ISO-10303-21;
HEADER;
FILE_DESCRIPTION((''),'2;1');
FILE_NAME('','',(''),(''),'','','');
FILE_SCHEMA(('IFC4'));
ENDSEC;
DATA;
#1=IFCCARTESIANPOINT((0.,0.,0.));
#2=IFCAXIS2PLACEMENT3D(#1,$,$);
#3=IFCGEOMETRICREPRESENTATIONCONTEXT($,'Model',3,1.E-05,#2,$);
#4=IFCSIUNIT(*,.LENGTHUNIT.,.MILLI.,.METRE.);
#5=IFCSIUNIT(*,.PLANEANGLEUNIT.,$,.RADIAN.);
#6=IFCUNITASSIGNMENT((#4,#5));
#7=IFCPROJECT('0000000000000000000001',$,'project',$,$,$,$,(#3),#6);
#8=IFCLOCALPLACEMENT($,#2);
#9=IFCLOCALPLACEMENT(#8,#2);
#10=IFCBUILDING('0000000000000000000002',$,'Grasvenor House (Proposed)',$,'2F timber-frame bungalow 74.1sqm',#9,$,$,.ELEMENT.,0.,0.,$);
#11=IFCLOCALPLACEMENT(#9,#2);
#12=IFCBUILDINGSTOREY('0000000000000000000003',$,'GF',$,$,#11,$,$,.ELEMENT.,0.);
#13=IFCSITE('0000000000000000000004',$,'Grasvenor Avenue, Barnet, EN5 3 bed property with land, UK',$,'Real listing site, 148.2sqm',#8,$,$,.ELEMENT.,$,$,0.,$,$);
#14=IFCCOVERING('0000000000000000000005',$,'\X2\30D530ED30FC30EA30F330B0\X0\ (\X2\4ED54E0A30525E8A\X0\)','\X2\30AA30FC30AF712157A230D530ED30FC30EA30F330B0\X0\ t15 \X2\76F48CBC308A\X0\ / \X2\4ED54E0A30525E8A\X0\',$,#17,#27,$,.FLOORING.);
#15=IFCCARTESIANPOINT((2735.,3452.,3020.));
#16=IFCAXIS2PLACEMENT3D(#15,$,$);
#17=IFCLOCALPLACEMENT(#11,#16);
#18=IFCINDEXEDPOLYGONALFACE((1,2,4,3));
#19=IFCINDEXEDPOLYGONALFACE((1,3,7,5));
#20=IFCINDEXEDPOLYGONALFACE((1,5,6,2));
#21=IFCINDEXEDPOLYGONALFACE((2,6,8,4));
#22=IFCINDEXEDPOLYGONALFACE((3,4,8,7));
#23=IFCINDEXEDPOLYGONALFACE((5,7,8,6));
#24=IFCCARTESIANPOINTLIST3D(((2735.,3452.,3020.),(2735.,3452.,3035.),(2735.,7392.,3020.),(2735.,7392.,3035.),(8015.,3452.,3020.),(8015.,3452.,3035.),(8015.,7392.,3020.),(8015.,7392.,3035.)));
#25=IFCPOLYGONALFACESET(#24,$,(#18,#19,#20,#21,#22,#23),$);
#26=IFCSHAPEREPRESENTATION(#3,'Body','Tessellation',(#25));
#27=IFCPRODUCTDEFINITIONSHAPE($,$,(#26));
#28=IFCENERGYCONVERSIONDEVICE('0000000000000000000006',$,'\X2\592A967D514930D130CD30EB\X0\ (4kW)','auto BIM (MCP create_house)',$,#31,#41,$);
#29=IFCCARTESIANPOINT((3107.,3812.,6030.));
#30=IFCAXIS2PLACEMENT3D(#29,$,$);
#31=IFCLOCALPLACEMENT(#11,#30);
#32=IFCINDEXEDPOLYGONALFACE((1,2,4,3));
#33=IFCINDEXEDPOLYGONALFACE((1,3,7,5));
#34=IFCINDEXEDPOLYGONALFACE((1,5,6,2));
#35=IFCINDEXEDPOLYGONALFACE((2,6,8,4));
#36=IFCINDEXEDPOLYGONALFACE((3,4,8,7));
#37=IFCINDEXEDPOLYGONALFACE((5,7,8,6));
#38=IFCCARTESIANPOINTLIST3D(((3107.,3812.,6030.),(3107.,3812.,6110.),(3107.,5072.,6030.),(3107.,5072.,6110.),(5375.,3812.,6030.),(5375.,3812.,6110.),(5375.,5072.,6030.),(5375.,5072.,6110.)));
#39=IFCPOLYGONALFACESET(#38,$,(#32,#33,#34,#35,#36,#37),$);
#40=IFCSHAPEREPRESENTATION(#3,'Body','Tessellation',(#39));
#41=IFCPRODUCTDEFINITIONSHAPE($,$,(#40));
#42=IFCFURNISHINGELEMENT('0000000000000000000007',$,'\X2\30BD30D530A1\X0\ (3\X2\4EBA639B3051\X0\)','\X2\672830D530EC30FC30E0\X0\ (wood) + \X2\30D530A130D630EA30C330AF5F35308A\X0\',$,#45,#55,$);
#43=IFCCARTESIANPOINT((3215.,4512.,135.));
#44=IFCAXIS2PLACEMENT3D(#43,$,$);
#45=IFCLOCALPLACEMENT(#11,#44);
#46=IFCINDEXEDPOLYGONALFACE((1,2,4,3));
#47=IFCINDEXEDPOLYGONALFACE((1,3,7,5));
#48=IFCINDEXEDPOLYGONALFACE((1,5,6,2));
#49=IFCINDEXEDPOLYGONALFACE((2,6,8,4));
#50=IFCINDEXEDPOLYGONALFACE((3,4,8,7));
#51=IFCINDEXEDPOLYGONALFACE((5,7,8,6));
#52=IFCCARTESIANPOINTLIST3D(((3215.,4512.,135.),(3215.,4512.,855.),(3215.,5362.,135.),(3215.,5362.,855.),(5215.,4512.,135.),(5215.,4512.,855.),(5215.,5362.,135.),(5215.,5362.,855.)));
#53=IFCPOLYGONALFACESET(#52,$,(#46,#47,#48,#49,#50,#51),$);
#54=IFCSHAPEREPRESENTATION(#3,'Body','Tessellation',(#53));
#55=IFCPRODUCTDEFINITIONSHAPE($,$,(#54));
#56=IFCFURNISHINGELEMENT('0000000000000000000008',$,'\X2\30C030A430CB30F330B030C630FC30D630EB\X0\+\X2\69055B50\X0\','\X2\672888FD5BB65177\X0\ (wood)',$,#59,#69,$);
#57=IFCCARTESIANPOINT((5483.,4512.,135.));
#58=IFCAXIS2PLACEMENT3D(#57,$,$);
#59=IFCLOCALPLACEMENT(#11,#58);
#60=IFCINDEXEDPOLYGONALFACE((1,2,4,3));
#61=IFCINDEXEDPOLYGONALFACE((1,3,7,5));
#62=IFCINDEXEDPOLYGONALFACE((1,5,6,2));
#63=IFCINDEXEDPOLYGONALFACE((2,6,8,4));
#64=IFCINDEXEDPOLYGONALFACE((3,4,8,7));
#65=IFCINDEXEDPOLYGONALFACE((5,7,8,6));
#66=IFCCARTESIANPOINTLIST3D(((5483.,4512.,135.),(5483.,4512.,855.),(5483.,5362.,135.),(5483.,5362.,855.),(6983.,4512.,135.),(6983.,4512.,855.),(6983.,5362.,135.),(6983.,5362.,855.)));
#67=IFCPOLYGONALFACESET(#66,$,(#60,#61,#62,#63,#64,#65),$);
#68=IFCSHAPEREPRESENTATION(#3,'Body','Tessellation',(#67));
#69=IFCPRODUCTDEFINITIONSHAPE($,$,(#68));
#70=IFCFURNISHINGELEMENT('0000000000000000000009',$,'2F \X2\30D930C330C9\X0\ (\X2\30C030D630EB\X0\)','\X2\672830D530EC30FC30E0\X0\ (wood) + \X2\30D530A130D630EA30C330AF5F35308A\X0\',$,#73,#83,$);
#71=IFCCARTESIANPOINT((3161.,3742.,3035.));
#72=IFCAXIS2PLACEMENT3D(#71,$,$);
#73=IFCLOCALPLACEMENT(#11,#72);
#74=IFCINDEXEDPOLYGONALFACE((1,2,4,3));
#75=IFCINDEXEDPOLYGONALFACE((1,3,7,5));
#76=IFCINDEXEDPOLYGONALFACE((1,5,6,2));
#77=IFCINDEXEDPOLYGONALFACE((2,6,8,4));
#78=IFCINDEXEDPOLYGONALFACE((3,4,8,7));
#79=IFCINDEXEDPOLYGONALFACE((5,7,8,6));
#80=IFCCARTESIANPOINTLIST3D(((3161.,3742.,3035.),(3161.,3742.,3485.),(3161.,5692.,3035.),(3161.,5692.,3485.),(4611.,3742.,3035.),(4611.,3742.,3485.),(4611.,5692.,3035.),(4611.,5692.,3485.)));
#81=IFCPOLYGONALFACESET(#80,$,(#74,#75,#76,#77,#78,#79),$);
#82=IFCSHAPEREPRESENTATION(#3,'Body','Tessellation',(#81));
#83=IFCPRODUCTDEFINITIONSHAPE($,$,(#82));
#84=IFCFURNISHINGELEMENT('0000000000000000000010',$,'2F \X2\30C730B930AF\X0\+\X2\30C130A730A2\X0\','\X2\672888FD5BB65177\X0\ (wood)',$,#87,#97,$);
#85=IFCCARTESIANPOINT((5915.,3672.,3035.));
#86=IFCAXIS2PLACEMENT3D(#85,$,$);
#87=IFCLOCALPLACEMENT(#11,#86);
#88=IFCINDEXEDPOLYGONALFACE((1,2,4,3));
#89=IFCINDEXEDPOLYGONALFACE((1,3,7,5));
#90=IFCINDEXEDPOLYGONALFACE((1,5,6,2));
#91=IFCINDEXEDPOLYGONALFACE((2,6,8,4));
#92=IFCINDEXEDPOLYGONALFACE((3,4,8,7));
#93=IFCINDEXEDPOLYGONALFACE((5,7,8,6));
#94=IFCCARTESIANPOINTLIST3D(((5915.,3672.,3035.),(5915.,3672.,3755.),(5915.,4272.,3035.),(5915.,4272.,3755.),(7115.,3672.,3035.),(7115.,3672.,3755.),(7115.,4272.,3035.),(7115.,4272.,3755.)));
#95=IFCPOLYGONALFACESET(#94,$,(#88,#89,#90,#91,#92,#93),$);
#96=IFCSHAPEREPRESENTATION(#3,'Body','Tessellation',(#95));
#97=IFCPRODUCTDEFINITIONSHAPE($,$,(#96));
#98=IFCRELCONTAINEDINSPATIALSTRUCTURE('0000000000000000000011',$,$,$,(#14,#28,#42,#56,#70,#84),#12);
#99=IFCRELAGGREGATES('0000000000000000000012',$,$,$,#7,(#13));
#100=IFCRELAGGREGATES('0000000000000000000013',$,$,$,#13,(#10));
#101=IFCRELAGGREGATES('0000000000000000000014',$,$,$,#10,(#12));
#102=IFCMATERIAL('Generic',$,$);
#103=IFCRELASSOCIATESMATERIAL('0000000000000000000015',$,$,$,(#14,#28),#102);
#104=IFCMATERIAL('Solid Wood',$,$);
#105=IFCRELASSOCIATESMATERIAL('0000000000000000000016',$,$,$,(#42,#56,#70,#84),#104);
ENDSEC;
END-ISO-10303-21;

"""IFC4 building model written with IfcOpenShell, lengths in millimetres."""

from ifc_helpers import new_model, si_unit, frame, frame_2d, origin, place, context, project, spatial, rectangle, extrude, material, element, save


model = new_model("IFC4")

# Units and contexts
model_context = context("Model", 3, precision=1e-05, world=origin())
ifc_project = project(units=[si_unit("LENGTHUNIT", "METRE", prefix="MILLI"), si_unit("PLANEANGLEUNIT", "RADIAN")], contexts=[model_context])

# Site, building, storey
site_placement = place(None, origin())
site = spatial("IfcSite", under=ifc_project, at=site_placement, Name="Grasvenor Avenue, Barnet, EN5 3 bed property with land, UK", ObjectType="Real listing site, 148.2sqm", CompositionType="ELEMENT", RefElevation=0.0)
building_placement = place(site_placement, origin())
building = spatial("IfcBuilding", under=site, at=building_placement, Name="Grasvenor House (Proposed)", ObjectType="2F timber-frame bungalow 74.1sqm", CompositionType="ELEMENT", ElevationOfRefHeight=0.0, ElevationOfTerrain=0.0)
storey_placement = place(building_placement, origin())
storey = spatial("IfcBuildingStorey", under=building, at=storey_placement, Name="GF", CompositionType="ELEMENT", Elevation=0.0)

# Shared definitions
ifc_material_1 = material(Name="Solid Wood")

# Covering
ifc_material_2 = material(Name="Generic")
covering_placement = place(storey_placement, frame((2735.0, 3452.0, 3020.0)))
element("IfcCovering", 1, at=covering_placement, inside=storey, material=ifc_material_2, Name="フローリング (仕上げ床)", Description="オーク無垢フローリング t15 直貼り / 仕上げ床", PredefinedType="FLOORING", context=model_context, shape_type="SweptSolid", body=[
    extrude(rectangle(XDim=5280.0, YDim=3940.0, at=frame_2d((2640.0, 1970.0))), frame((2735.0, 3452.0, 3020.0)), (0.0, 0.0, 1.0), 15.0),
])

# Energy conversion device
energy_conversion_device_placement = place(storey_placement, frame((3107.0, 3812.0, 6030.0)))
element("IfcEnergyConversionDevice", 2, at=energy_conversion_device_placement, inside=storey, material=ifc_material_2, Name="太陽光パネル (4kW)", Description="auto BIM (MCP create_house)", context=model_context, shape_type="SweptSolid", body=[
    extrude(rectangle(XDim=2268.0, YDim=1260.0, at=frame_2d((1134.0, 630.0))), frame((3107.0, 3812.0, 6030.0)), (0.0, 0.0, 1.0), 80.0),
])

# Furnishing elements
furnishing_1_placement = place(storey_placement, frame((3215.0, 4512.0, 135.0)))
element("IfcFurnishingElement", 3, at=furnishing_1_placement, inside=storey, material=ifc_material_1, Name="ソファ (3人掛け)", Description="木フレーム (wood) + ファブリック張り", context=model_context, shape_type="SweptSolid", body=[
    extrude(rectangle(XDim=2000.0, YDim=850.0, at=frame_2d((1000.0, 425.0))), frame((3215.0, 4512.0, 135.0)), (0.0, 0.0, 1.0), 720.0),
])
furnishing_2_placement = place(storey_placement, frame((5483.0, 4512.0, 135.0)))
element("IfcFurnishingElement", 4, at=furnishing_2_placement, inside=storey, material=ifc_material_1, Name="ダイニングテーブル+椅子", Description="木製家具 (wood)", context=model_context, shape_type="SweptSolid", body=[
    extrude(rectangle(XDim=1500.0, YDim=850.0, at=frame_2d((750.0, 425.0))), frame((5483.0, 4512.0, 135.0)), (0.0, 0.0, 1.0), 720.0),
])
furnishing_3_placement = place(storey_placement, frame((3161.0, 3742.0, 3035.0)))
element("IfcFurnishingElement", 5, at=furnishing_3_placement, inside=storey, material=ifc_material_1, Name="2F ベッド (ダブル)", Description="木フレーム (wood) + ファブリック張り", context=model_context, shape_type="SweptSolid", body=[
    extrude(rectangle(XDim=1450.0, YDim=1950.0, at=frame_2d((725.0, 975.0))), frame((3161.0, 3742.0, 3035.0)), (0.0, 0.0, 1.0), 450.0),
])
furnishing_4_placement = place(storey_placement, frame((5915.0, 3672.0, 3035.0)))
element("IfcFurnishingElement", 6, at=furnishing_4_placement, inside=storey, material=ifc_material_1, Name="2F デスク+チェア", Description="木製家具 (wood)", context=model_context, shape_type="SweptSolid", body=[
    extrude(rectangle(XDim=1200.0, YDim=600.0, at=frame_2d((600.0, 300.0))), frame((5915.0, 3672.0, 3035.0)), (0.0, 0.0, 1.0), 720.0),
])

save(model, "model.ifc")
